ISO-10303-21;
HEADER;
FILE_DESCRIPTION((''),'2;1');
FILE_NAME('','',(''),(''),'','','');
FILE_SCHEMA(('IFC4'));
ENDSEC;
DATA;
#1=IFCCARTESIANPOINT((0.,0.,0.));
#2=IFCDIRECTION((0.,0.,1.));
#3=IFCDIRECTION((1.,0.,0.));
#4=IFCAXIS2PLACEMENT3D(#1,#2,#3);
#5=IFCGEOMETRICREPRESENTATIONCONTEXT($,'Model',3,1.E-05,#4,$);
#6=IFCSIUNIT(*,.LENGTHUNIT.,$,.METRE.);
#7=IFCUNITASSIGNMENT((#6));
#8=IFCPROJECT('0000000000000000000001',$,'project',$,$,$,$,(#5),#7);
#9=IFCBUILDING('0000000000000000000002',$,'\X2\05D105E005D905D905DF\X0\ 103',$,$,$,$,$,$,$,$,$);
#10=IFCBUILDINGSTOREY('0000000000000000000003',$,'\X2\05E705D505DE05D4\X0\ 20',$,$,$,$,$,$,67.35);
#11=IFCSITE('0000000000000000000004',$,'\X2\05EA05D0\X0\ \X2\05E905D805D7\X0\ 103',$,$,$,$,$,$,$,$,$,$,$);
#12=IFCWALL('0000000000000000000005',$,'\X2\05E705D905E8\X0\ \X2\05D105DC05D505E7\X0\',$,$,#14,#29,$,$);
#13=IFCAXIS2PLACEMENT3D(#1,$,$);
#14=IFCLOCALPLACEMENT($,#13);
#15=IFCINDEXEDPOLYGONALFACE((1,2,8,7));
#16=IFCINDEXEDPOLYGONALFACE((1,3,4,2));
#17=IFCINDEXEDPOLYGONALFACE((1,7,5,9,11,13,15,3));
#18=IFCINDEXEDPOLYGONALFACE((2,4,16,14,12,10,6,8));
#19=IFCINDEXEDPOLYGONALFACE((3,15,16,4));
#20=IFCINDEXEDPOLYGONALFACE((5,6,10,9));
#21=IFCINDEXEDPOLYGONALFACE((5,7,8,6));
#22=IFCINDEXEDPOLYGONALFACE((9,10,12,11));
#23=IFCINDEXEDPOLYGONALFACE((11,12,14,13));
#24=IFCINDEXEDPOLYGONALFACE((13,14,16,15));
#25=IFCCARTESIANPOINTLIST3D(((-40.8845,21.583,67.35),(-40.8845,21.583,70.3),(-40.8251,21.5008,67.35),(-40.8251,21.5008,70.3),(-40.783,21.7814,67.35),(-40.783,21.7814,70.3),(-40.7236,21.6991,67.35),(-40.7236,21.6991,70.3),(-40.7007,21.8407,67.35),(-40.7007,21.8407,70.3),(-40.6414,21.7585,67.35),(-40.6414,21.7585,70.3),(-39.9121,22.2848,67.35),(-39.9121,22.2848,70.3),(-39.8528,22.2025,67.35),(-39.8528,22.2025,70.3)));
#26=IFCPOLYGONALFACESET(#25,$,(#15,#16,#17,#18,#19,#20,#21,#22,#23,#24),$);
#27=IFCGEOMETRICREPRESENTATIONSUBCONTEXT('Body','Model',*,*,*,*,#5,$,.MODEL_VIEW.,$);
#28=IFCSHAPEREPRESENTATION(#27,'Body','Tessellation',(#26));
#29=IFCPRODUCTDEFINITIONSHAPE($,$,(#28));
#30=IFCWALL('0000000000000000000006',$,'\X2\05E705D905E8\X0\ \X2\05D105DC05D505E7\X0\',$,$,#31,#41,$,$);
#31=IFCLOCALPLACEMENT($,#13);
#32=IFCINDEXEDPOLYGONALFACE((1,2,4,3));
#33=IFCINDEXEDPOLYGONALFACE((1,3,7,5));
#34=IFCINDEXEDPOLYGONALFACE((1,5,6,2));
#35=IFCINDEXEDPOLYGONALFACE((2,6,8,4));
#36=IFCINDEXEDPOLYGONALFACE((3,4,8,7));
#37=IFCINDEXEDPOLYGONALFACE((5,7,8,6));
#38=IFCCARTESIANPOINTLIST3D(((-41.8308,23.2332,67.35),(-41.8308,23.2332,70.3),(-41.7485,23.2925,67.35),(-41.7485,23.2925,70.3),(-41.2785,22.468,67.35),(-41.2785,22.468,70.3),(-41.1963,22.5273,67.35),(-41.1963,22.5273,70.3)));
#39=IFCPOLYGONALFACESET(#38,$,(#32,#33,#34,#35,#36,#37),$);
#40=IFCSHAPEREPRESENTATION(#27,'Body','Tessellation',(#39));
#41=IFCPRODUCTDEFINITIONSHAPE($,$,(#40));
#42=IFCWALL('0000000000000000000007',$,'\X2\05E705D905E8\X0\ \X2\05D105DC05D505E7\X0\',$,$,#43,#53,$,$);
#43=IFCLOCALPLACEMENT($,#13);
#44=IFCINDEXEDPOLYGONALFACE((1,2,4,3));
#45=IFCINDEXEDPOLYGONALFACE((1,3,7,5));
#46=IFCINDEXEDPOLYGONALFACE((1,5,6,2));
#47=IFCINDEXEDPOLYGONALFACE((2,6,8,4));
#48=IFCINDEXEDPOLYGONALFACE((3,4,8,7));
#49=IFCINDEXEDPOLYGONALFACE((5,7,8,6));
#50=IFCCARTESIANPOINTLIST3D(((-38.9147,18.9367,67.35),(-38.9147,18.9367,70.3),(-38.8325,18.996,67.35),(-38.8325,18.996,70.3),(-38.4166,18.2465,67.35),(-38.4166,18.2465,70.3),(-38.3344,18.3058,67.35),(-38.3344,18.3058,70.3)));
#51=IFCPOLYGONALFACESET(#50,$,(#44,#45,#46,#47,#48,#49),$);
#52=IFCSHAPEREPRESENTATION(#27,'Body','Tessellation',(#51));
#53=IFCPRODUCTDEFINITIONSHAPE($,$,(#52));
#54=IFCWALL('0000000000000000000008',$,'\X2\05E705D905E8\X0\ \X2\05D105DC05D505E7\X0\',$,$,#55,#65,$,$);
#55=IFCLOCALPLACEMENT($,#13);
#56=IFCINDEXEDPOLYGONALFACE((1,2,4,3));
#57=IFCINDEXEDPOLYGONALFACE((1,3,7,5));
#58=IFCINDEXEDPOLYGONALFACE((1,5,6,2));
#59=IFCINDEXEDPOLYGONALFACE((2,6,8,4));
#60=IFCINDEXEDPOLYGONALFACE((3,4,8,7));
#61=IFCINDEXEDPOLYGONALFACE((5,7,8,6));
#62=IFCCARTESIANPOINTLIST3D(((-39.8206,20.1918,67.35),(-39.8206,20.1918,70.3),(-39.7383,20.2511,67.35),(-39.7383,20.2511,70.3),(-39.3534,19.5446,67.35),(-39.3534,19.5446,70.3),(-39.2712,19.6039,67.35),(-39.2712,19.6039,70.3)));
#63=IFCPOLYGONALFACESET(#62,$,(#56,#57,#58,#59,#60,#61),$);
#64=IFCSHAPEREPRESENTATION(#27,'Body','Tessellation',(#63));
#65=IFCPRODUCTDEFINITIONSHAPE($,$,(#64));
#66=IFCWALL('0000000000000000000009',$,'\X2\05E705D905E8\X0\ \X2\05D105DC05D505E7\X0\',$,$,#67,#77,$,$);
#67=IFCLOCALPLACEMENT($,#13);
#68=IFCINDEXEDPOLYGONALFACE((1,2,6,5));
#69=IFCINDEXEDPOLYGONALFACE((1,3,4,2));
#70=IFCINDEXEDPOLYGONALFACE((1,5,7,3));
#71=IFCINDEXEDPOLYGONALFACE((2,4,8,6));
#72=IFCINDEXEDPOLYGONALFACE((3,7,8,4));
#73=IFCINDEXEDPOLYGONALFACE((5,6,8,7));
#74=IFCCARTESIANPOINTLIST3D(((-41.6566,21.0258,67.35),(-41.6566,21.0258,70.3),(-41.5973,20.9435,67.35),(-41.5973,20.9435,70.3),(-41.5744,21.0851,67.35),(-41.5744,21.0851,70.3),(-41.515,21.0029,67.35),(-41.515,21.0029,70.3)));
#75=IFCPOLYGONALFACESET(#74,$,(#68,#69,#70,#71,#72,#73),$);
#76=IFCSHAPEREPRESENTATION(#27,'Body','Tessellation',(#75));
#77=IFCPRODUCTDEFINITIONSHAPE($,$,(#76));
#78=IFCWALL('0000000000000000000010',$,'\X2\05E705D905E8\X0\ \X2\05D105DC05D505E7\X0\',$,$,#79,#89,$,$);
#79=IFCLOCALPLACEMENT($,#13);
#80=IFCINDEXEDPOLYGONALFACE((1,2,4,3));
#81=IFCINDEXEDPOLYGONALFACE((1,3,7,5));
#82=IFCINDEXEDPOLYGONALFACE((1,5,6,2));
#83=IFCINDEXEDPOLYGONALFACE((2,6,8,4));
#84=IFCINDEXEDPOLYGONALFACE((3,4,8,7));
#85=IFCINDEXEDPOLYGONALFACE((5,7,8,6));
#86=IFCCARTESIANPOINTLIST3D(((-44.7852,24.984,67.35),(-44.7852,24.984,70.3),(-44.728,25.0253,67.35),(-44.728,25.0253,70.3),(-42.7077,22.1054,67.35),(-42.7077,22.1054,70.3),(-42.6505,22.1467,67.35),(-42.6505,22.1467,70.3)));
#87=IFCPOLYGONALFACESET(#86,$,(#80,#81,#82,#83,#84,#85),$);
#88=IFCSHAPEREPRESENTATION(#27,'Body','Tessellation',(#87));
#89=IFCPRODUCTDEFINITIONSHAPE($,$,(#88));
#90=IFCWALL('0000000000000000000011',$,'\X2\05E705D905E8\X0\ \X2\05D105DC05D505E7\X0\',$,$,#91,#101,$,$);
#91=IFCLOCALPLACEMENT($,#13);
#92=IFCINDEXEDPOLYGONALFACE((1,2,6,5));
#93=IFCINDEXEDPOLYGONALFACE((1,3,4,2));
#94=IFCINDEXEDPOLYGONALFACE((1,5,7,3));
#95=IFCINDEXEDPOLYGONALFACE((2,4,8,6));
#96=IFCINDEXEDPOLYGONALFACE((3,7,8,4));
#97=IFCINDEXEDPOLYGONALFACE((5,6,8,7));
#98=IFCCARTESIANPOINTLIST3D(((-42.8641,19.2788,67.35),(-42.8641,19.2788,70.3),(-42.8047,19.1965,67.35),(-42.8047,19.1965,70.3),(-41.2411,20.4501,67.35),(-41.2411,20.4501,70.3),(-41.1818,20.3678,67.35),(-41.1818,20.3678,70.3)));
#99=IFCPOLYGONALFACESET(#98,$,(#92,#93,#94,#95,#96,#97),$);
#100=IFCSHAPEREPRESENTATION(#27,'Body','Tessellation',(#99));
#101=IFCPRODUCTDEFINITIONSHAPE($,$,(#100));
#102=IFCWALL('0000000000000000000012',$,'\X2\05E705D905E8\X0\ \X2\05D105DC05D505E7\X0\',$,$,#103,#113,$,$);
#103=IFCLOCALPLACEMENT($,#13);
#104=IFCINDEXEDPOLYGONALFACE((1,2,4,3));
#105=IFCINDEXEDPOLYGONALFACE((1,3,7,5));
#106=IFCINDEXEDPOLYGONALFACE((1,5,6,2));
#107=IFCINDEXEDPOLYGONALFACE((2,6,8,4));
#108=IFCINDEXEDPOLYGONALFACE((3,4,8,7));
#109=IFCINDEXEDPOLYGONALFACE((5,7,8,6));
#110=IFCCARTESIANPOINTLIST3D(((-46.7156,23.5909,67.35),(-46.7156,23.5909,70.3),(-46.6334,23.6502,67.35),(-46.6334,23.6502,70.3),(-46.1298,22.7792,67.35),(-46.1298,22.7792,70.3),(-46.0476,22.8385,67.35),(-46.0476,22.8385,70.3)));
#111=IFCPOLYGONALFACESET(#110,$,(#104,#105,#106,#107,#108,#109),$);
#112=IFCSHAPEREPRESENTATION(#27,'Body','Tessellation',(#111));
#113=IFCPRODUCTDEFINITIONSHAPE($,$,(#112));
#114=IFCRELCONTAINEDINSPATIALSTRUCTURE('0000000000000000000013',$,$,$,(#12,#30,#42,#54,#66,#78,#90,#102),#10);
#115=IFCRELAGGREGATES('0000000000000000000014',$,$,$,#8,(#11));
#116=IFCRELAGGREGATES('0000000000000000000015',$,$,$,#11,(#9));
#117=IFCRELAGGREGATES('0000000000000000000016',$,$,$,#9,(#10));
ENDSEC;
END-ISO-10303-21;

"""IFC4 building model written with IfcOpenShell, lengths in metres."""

from ifc_helpers import new_model, si_unit, frame, origin_with_axes, context, subcontext, project, spatial, polyline, outline, extrude, element, save


model = new_model("IFC4")

# Units and contexts
model_context = context("Model", 3, precision=1e-05, world=origin_with_axes())
body_context = subcontext(model_context, "Body", "Model", "MODEL_VIEW")
ifc_project = project(units=[si_unit("LENGTHUNIT", "METRE")], contexts=[model_context])

# Site, building, storey
site = spatial("IfcSite", under=ifc_project, Name="תא שטח 103")
building = spatial("IfcBuilding", under=site, Name="בניין 103")
storey = spatial("IfcBuildingStorey", under=building, Name="קומה 20", Elevation=67.35)

# Walls
element("IfcWall", 1, inside=storey, Name="קיר בלוק", context=body_context, shape_type="SweptSolid", body=[
    extrude(outline(polyline([(-40.783, 21.7814), (-40.7007, 21.8407), (-40.6414, 21.7585), (-39.9121, 22.2848), (-39.8528, 22.2025), (-40.8251, 21.5008), (-40.8845, 21.583), (-40.7236, 21.6991), (-40.783, 21.7814)])), frame((0.0, 0.0, 67.35)), (0.0, 0.0, 1.0), 2.95),
])
element("IfcWall", 2, inside=storey, Name="קיר בלוק", context=body_context, shape_type="SweptSolid", body=[
    extrude(outline(polyline([(-41.1963, 22.5273), (-41.2785, 22.468), (-41.8308, 23.2332), (-41.7485, 23.2925), (-41.1963, 22.5273)])), frame((0.0, 0.0, 67.35)), (0.0, 0.0, 1.0), 2.95),
])
element("IfcWall", 3, inside=storey, Name="קיר בלוק", context=body_context, shape_type="SweptSolid", body=[
    extrude(outline(polyline([(-38.4166, 18.2465), (-38.9147, 18.9367), (-38.8325, 18.996), (-38.3344, 18.3058), (-38.4166, 18.2465)])), frame((0.0, 0.0, 67.35)), (0.0, 0.0, 1.0), 2.95),
])
element("IfcWall", 4, inside=storey, Name="קיר בלוק", context=body_context, shape_type="SweptSolid", body=[
    extrude(outline(polyline([(-39.2712, 19.6039), (-39.3534, 19.5446), (-39.8206, 20.1918), (-39.7383, 20.2511), (-39.2712, 19.6039)])), frame((0.0, 0.0, 67.35)), (0.0, 0.0, 1.0), 2.95),
])
element("IfcWall", 5, inside=storey, Name="קיר בלוק", context=body_context, shape_type="SweptSolid", body=[
    extrude(outline(polyline([(-41.5744, 21.0851), (-41.515, 21.0029), (-41.5973, 20.9435), (-41.6566, 21.0258), (-41.5744, 21.0851)])), frame((0.0, 0.0, 67.35)), (0.0, 0.0, 1.0), 2.95),
])
element("IfcWall", 6, inside=storey, Name="קיר בלוק", context=body_context, shape_type="SweptSolid", body=[
    extrude(outline(polyline([(-42.6505, 22.1467), (-42.7077, 22.1054), (-44.7852, 24.984), (-44.728, 25.0253), (-42.6505, 22.1467)])), frame((0.0, 0.0, 67.35)), (0.0, 0.0, 1.0), 2.95),
])
element("IfcWall", 7, inside=storey, Name="קיר בלוק", context=body_context, shape_type="SweptSolid", body=[
    extrude(outline(polyline([(-42.8047, 19.1965), (-42.8641, 19.2788), (-41.2411, 20.4501), (-41.1818, 20.3678), (-42.8047, 19.1965)])), frame((0.0, 0.0, 67.35)), (0.0, 0.0, 1.0), 2.95),
])
element("IfcWall", 8, inside=storey, Name="קיר בלוק", context=body_context, shape_type="SweptSolid", body=[
    extrude(outline(polyline([(-46.6334, 23.6502), (-46.0476, 22.8385), (-46.1298, 22.7792), (-46.7156, 23.5909), (-46.6334, 23.6502)])), frame((0.0, 0.0, 67.35)), (0.0, 0.0, 1.0), 2.95),
])

save(model, "model.ifc")
